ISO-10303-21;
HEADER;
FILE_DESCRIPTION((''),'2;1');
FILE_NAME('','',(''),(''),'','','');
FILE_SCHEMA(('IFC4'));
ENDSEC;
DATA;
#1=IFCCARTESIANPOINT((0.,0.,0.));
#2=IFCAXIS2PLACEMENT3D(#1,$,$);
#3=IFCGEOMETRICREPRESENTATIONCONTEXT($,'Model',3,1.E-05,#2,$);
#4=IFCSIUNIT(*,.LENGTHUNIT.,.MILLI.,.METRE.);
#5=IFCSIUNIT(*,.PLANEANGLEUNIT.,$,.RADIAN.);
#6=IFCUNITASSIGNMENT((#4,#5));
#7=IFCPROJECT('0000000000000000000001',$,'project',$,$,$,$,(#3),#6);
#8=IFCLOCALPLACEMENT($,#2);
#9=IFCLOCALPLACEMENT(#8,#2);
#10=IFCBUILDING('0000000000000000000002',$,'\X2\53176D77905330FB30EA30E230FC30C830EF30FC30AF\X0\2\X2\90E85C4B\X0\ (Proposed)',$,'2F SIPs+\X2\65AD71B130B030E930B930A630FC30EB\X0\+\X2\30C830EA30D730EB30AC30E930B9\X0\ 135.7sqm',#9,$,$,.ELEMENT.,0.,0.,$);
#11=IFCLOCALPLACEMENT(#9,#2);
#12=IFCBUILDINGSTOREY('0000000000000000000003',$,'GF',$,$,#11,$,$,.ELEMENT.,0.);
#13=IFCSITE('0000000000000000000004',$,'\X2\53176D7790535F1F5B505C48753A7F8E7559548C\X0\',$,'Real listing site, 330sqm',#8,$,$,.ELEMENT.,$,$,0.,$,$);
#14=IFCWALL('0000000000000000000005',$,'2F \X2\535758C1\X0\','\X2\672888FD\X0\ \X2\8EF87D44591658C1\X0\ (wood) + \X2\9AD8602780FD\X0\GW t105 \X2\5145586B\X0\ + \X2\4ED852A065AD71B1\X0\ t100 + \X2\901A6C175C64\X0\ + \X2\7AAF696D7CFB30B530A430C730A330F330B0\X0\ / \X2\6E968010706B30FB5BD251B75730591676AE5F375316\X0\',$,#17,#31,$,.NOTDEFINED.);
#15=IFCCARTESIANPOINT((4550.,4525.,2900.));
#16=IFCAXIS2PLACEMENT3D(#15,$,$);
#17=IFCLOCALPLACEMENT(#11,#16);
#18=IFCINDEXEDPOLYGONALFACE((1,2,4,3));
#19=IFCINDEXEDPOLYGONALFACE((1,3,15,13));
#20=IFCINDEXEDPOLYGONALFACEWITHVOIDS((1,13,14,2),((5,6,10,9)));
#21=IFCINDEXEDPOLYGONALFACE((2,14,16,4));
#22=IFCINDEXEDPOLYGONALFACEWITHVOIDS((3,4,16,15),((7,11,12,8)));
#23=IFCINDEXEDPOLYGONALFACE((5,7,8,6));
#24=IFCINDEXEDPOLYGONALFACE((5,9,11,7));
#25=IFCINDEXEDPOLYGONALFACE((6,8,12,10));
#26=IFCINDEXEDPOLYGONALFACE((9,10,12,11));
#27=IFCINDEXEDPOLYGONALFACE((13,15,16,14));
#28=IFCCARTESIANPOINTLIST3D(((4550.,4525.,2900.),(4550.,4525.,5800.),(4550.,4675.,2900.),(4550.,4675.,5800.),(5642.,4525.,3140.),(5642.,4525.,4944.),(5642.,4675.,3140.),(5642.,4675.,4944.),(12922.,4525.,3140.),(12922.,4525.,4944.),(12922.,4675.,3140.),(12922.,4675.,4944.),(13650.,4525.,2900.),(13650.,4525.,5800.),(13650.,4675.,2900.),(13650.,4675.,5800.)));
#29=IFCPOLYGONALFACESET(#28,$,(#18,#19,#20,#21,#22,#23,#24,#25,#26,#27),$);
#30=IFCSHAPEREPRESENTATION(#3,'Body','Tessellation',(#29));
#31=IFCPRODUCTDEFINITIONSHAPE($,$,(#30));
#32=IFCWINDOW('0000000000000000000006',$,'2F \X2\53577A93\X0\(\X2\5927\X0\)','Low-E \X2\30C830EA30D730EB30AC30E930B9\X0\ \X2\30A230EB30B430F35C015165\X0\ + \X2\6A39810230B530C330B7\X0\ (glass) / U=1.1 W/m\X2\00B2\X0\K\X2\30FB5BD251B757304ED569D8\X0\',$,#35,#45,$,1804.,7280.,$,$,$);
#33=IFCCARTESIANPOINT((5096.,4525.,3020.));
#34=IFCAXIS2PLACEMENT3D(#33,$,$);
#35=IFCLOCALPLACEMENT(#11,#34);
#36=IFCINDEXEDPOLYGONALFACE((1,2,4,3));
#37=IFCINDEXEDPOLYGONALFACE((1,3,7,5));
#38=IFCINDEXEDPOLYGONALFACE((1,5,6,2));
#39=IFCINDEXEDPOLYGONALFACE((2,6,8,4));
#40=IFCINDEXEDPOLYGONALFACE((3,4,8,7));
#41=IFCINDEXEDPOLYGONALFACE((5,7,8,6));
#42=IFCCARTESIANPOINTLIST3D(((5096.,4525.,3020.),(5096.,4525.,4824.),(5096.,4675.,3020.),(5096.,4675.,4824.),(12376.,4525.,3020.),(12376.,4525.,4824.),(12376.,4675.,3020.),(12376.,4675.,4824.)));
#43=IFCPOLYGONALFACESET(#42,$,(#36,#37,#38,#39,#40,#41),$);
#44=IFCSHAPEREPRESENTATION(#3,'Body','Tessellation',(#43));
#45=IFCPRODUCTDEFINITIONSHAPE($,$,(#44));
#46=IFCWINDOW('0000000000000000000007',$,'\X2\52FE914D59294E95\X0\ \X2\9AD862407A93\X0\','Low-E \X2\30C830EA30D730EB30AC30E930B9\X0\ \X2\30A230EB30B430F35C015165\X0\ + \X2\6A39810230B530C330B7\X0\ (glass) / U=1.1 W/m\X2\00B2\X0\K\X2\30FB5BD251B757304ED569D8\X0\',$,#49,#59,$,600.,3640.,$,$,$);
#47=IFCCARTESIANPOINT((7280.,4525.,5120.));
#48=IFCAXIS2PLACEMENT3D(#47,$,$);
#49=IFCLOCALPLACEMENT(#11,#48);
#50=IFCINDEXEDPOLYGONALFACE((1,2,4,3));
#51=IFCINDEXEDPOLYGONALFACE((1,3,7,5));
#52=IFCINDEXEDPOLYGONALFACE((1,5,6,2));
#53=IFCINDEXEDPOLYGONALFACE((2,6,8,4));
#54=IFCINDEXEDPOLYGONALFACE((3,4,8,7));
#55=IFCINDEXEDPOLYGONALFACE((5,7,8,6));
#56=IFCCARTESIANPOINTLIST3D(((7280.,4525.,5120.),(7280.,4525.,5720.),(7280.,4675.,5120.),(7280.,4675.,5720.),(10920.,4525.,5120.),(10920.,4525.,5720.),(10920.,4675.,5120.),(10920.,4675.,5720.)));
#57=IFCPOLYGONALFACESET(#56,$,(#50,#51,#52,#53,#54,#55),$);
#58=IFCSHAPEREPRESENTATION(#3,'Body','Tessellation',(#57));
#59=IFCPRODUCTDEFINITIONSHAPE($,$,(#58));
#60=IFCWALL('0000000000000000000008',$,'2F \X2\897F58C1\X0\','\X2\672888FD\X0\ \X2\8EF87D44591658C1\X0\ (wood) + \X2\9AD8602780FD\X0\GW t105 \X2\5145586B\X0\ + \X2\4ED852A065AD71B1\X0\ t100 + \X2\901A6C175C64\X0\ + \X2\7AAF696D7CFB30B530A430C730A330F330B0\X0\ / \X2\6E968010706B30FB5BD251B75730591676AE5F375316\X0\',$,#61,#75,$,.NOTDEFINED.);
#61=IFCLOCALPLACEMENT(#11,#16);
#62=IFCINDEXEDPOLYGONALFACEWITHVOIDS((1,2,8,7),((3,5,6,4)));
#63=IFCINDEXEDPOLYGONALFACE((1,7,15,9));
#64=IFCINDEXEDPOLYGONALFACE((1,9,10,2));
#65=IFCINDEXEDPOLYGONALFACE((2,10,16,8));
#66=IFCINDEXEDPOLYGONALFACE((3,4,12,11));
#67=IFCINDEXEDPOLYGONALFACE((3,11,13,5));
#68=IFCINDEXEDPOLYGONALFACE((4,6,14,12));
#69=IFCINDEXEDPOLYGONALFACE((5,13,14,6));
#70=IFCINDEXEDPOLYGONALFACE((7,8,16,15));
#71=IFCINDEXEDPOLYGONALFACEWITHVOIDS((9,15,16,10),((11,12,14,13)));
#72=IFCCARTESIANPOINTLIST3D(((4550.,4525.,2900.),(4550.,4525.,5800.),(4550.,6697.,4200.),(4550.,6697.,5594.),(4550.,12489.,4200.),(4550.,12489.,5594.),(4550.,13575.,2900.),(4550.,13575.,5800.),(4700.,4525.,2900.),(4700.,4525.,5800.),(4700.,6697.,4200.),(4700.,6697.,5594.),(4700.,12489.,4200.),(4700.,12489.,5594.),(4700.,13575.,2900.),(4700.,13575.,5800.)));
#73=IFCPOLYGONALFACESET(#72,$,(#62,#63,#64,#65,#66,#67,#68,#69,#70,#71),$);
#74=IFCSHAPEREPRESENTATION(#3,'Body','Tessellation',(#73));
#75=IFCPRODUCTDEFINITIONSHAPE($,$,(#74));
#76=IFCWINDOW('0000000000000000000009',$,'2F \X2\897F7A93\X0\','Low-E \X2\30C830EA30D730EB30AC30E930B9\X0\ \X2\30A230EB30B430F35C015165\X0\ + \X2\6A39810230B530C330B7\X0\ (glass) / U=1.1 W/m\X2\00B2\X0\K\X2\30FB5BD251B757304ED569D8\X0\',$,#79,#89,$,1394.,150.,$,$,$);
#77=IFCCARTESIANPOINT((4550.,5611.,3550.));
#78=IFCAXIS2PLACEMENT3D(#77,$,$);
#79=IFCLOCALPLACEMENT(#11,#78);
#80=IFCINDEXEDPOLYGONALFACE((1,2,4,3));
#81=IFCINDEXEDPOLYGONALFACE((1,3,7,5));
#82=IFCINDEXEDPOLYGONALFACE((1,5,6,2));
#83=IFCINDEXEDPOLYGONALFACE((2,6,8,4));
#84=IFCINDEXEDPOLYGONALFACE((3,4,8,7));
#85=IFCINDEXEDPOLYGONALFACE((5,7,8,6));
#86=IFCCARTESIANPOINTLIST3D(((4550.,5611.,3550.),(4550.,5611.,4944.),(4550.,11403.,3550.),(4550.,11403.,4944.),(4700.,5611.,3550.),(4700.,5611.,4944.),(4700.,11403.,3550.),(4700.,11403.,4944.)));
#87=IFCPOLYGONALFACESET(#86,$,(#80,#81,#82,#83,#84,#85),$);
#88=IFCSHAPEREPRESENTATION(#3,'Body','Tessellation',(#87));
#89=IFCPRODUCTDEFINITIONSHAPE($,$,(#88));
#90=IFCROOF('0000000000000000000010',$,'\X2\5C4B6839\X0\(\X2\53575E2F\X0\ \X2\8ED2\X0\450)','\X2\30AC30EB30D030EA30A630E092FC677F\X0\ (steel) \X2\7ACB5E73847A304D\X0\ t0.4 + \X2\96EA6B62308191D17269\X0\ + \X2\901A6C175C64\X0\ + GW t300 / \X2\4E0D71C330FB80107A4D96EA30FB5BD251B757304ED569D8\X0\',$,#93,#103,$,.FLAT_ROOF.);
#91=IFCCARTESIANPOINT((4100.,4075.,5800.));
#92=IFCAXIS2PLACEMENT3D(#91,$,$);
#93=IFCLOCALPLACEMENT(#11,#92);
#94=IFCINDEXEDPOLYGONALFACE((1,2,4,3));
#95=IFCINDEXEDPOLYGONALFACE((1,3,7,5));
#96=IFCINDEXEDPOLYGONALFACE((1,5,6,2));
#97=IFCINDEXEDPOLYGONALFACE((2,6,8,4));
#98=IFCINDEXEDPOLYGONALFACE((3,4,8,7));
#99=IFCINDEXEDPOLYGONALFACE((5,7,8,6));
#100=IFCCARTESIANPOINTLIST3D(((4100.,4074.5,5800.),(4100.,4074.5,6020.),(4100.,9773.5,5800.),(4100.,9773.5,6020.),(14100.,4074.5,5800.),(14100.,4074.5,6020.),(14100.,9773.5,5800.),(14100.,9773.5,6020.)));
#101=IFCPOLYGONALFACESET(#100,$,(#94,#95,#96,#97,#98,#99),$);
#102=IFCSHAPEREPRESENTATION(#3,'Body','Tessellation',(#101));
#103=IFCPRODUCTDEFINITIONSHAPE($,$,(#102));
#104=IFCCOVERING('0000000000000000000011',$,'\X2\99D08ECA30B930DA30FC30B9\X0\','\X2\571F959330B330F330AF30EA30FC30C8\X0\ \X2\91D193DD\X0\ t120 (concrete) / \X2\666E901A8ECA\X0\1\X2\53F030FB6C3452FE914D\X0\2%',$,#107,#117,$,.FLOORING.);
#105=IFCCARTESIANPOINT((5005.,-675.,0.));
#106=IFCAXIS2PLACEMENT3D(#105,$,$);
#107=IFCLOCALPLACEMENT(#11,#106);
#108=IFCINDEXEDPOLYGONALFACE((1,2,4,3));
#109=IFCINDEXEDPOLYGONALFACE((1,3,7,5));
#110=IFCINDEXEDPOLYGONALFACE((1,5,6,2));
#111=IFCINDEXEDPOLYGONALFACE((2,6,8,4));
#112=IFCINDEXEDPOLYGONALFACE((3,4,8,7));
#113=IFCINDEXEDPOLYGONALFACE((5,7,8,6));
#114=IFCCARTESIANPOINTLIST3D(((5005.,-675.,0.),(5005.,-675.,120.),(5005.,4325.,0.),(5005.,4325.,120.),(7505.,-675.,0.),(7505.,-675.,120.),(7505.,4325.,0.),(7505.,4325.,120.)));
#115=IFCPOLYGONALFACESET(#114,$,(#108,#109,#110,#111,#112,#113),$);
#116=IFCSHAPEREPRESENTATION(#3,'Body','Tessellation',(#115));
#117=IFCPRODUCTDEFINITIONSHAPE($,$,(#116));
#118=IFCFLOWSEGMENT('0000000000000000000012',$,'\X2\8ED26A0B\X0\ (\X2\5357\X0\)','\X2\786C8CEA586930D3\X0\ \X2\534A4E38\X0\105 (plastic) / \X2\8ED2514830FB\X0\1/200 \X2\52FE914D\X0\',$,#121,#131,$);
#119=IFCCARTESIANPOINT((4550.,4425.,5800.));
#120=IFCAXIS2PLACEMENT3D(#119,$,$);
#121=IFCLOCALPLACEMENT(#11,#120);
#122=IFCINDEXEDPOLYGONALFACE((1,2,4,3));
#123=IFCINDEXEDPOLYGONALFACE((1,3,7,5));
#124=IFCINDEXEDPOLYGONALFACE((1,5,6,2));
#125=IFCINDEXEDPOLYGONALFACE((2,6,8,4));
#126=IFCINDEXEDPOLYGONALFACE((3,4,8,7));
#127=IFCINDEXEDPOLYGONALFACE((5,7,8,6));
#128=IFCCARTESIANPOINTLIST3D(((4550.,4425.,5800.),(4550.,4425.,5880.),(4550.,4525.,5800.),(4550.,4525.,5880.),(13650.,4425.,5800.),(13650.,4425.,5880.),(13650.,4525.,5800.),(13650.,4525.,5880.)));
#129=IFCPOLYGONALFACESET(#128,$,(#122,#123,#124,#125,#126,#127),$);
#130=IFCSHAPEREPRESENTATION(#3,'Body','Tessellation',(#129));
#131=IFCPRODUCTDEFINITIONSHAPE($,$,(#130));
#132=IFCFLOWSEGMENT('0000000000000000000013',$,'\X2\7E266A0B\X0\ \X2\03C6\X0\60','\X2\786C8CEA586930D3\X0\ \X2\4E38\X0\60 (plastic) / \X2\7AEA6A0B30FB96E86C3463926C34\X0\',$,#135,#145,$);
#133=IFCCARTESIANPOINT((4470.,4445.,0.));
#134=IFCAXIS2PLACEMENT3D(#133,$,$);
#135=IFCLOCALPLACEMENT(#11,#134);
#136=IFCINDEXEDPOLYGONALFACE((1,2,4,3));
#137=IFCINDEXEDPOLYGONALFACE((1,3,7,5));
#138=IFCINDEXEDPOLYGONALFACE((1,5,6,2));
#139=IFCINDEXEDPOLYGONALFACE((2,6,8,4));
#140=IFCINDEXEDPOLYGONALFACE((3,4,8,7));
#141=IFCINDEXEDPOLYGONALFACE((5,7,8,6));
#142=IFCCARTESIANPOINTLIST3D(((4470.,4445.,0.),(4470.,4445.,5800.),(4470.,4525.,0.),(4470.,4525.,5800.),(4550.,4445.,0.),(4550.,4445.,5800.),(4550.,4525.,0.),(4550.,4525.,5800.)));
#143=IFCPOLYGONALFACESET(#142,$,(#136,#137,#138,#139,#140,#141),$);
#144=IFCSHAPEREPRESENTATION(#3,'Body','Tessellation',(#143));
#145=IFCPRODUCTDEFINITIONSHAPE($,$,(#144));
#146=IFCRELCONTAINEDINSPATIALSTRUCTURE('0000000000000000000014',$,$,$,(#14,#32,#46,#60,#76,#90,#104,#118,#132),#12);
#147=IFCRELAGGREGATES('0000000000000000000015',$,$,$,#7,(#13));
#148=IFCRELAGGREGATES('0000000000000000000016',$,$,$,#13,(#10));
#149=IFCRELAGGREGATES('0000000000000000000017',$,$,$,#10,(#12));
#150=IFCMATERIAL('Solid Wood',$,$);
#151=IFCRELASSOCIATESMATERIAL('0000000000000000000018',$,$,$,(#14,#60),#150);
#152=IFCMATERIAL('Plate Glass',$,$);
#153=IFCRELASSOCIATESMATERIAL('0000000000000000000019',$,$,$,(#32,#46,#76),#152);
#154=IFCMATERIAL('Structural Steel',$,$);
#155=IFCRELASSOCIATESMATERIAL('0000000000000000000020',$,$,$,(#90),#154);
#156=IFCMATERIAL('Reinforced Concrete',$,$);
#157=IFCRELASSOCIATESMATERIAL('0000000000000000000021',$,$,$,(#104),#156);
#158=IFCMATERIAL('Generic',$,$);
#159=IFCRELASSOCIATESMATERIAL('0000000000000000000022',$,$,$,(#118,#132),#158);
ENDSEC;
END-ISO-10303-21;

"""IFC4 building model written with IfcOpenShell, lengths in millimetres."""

from ifc_helpers import new_model, si_unit, frame, frame_2d, origin, place, context, project, spatial, rectangle, extrude, material, element, fill, save


model = new_model("IFC4")

# Units and contexts
model_context = context("Model", 3, precision=1e-05, world=origin())
ifc_project = project(units=[si_unit("LENGTHUNIT", "METRE", prefix="MILLI"), si_unit("PLANEANGLEUNIT", "RADIAN")], contexts=[model_context])

# Site, building, storey
site_placement = place(None, origin())
site = spatial("IfcSite", under=ifc_project, at=site_placement, Name="北海道弟子屈町美留和", ObjectType="Real listing site, 330sqm", CompositionType="ELEMENT", RefElevation=0.0)
building_placement = place(site_placement, origin())
building = spatial("IfcBuilding", under=site, at=building_placement, Name="北海道・リモートワーク2部屋 (Proposed)", ObjectType="2F SIPs+断熱グラスウール+トリプルガラス 135.7sqm", CompositionType="ELEMENT", ElevationOfRefHeight=0.0, ElevationOfTerrain=0.0)
storey_placement = place(building_placement, origin())
storey = spatial("IfcBuildingStorey", under=building, at=storey_placement, Name="GF", CompositionType="ELEMENT", Elevation=0.0)

# Shared definitions
ifc_material_1 = material(Name="Solid Wood")

# Shared definitions
ifc_material_2 = material(Name="Reinforced Concrete")

# Shared definitions
ifc_material_3 = material(Name="Plate Glass")

# Wall, openings, windows
wall_1_placement = place(storey_placement, frame((4550.0, 4525.0, 2900.0)))
wall_1 = element("IfcWall", 1, at=wall_1_placement, inside=storey, material=ifc_material_1, Name="2F 南壁", Description="木製 軸組外壁 (wood) + 高性能GW t105 充填 + 付加断熱 t100 + 通気層 + 窯業系サイディング / 準耐火・寒冷地外皮強化", PredefinedType="NOTDEFINED", context=model_context, shape_type="SweptSolid", body=[
    extrude(rectangle(XDim=9100.0, YDim=150.0, at=frame_2d((4550.0, 75.0))), frame((4550.0, 4525.0, 2900.0)), (0.0, 0.0, 1.0), 2900.0),
])
opening_1_placement = place(storey_placement, frame((5096.0, 4525.0, 3020.0)))
opening_1 = element("IfcOpeningElement", 2, at=opening_1_placement, cuts=wall_1, PredefinedType="NOTDEFINED", context=model_context, shape_type="SweptSolid", body=[
    extrude(rectangle(XDim=7280.0, YDim=150.0, at=frame_2d((3640.0, 75.0))), frame((5096.0, 4525.0, 3020.0)), (0.0, 0.0, 1.0), 1804.0),
])
opening_2_placement = place(storey_placement, frame((7280.0, 4525.0, 5120.0)))
opening_2 = element("IfcOpeningElement", 3, at=opening_2_placement, cuts=wall_1, PredefinedType="NOTDEFINED", context=model_context, shape_type="SweptSolid", body=[
    extrude(rectangle(XDim=3640.0, YDim=150.0, at=frame_2d((1820.0, 75.0))), frame((7280.0, 4525.0, 5120.0)), (0.0, 0.0, 1.0), 600.0),
])
window_1_placement = place(storey_placement, frame((5096.0, 4525.0, 3020.0)))
window_1 = element("IfcWindow", 4, at=window_1_placement, inside=storey, material=ifc_material_3, Name="2F 南窓(大)", Description="Low-E トリプルガラス アルゴン封入 + 樹脂サッシ (glass) / U=1.1 W/m²K・寒冷地仕様", OverallHeight=1804.0, OverallWidth=7280.0, context=model_context, shape_type="SweptSolid", body=[
    extrude(rectangle(XDim=7280.0, YDim=150.0, at=frame_2d((3640.0, 75.0))), frame((5096.0, 4525.0, 3020.0)), (0.0, 0.0, 1.0), 1804.0),
])
fill(opening_1, window_1)
window_2_placement = place(storey_placement, frame((7280.0, 4525.0, 5120.0)))
window_2 = element("IfcWindow", 5, at=window_2_placement, inside=storey, material=ifc_material_3, Name="勾配天井 高所窓", Description="Low-E トリプルガラス アルゴン封入 + 樹脂サッシ (glass) / U=1.1 W/m²K・寒冷地仕様", OverallHeight=600.0, OverallWidth=3640.0, context=model_context, shape_type="SweptSolid", body=[
    extrude(rectangle(XDim=3640.0, YDim=150.0, at=frame_2d((1820.0, 75.0))), frame((7280.0, 4525.0, 5120.0)), (0.0, 0.0, 1.0), 600.0),
])
fill(opening_2, window_2)

# Wall, opening, window
wall_2_placement = place(storey_placement, frame((4550.0, 4525.0, 2900.0)))
wall_2 = element("IfcWall", 6, at=wall_2_placement, inside=storey, material=ifc_material_1, Name="2F 西壁", Description="木製 軸組外壁 (wood) + 高性能GW t105 充填 + 付加断熱 t100 + 通気層 + 窯業系サイディング / 準耐火・寒冷地外皮強化", PredefinedType="NOTDEFINED", context=model_context, shape_type="SweptSolid", body=[
    extrude(rectangle(XDim=150.0, YDim=9050.0, at=frame_2d((75.0, 4525.0))), frame((4550.0, 4525.0, 2900.0)), (0.0, 0.0, 1.0), 2900.0),
])
opening_3_placement = place(storey_placement, frame((4550.0, 5611.0, 3550.0)))
opening_3 = element("IfcOpeningElement", 7, at=opening_3_placement, cuts=wall_2, PredefinedType="NOTDEFINED", context=model_context, shape_type="SweptSolid", body=[
    extrude(rectangle(XDim=150.0, YDim=5792.0, at=frame_2d((75.0, 2896.0))), frame((4550.0, 5611.0, 3550.0)), (0.0, 0.0, 1.0), 1394.0),
])
window_3_placement = place(storey_placement, frame((4550.0, 5611.0, 3550.0)))
window_3 = element("IfcWindow", 8, at=window_3_placement, inside=storey, material=ifc_material_3, Name="2F 西窓", Description="Low-E トリプルガラス アルゴン封入 + 樹脂サッシ (glass) / U=1.1 W/m²K・寒冷地仕様", OverallHeight=1394.0, OverallWidth=150.0, context=model_context, shape_type="SweptSolid", body=[
    extrude(rectangle(XDim=150.0, YDim=5792.0, at=frame_2d((75.0, 2896.0))), frame((4550.0, 5611.0, 3550.0)), (0.0, 0.0, 1.0), 1394.0),
])
fill(opening_3, window_3)

# Roof
ifc_material_4 = material(Name="Structural Steel")
for number, where, name in (
    (9, (4100.0, 4075.0, 5800.0), "屋根(南帯 軒450)"),
):
    element("IfcRoof", number, at=place(storey_placement, frame(where)), inside=storey, material=ifc_material_4, Name=name, Description="ガルバリウム鋼板 (steel) 立平葺き t0.4 + 雪止め金物 + 通気層 + GW t300 / 不燃・耐積雪・寒冷地仕様", PredefinedType="FLAT_ROOF", context=model_context, shape_type="SweptSolid", body=[
        extrude(rectangle(XDim=10000.0, YDim=5699.0, at=frame_2d((5000.0, 2849.0))), frame((4100.0, 4075.0, 5800.0)), (0.0, 0.0, 1.0), 220.0),
    ])

# Covering
covering_placement = place(storey_placement, frame((5005.0, -675.0, 0.0)))
element("IfcCovering", 10, at=covering_placement, inside=storey, material=ifc_material_2, Name="駐車スペース", Description="土間コンクリート 金鏝 t120 (concrete) / 普通車1台・水勾配2%", PredefinedType="FLOORING", context=model_context, shape_type="SweptSolid", body=[
    extrude(rectangle(XDim=2500.0, YDim=5000.0, at=frame_2d((1250.0, 2500.0))), frame((5005.0, -675.0, 0.0)), (0.0, 0.0, 1.0), 120.0),
])

# Flow segments
ifc_material_5 = material(Name="Generic")
flow_segment_1_placement = place(storey_placement, frame((4550.0, 4425.0, 5800.0)))
element("IfcFlowSegment", 11, at=flow_segment_1_placement, inside=storey, material=ifc_material_5, Name="軒樋 (南)", Description="硬質塩ビ 半丸105 (plastic) / 軒先・1/200 勾配", context=model_context, shape_type="SweptSolid", body=[
    extrude(rectangle(XDim=9100.0, YDim=100.0, at=frame_2d((4550.0, 50.0))), frame((4550.0, 4425.0, 5800.0)), (0.0, 0.0, 1.0), 80.0),
])
flow_segment_2_placement = place(storey_placement, frame((4470.0, 4445.0, 0.0)))
element("IfcFlowSegment", 12, at=flow_segment_2_placement, inside=storey, material=ifc_material_5, Name="縦樋 φ60", Description="硬質塩ビ 丸60 (plastic) / 竪樋・雨水排水", context=model_context, shape_type="SweptSolid", body=[
    extrude(rectangle(XDim=80.0, YDim=80.0, at=frame_2d((40.0, 40.0))), frame((4470.0, 4445.0, 0.0)), (0.0, 0.0, 1.0), 5800.0),
])

save(model, "model.ifc")
